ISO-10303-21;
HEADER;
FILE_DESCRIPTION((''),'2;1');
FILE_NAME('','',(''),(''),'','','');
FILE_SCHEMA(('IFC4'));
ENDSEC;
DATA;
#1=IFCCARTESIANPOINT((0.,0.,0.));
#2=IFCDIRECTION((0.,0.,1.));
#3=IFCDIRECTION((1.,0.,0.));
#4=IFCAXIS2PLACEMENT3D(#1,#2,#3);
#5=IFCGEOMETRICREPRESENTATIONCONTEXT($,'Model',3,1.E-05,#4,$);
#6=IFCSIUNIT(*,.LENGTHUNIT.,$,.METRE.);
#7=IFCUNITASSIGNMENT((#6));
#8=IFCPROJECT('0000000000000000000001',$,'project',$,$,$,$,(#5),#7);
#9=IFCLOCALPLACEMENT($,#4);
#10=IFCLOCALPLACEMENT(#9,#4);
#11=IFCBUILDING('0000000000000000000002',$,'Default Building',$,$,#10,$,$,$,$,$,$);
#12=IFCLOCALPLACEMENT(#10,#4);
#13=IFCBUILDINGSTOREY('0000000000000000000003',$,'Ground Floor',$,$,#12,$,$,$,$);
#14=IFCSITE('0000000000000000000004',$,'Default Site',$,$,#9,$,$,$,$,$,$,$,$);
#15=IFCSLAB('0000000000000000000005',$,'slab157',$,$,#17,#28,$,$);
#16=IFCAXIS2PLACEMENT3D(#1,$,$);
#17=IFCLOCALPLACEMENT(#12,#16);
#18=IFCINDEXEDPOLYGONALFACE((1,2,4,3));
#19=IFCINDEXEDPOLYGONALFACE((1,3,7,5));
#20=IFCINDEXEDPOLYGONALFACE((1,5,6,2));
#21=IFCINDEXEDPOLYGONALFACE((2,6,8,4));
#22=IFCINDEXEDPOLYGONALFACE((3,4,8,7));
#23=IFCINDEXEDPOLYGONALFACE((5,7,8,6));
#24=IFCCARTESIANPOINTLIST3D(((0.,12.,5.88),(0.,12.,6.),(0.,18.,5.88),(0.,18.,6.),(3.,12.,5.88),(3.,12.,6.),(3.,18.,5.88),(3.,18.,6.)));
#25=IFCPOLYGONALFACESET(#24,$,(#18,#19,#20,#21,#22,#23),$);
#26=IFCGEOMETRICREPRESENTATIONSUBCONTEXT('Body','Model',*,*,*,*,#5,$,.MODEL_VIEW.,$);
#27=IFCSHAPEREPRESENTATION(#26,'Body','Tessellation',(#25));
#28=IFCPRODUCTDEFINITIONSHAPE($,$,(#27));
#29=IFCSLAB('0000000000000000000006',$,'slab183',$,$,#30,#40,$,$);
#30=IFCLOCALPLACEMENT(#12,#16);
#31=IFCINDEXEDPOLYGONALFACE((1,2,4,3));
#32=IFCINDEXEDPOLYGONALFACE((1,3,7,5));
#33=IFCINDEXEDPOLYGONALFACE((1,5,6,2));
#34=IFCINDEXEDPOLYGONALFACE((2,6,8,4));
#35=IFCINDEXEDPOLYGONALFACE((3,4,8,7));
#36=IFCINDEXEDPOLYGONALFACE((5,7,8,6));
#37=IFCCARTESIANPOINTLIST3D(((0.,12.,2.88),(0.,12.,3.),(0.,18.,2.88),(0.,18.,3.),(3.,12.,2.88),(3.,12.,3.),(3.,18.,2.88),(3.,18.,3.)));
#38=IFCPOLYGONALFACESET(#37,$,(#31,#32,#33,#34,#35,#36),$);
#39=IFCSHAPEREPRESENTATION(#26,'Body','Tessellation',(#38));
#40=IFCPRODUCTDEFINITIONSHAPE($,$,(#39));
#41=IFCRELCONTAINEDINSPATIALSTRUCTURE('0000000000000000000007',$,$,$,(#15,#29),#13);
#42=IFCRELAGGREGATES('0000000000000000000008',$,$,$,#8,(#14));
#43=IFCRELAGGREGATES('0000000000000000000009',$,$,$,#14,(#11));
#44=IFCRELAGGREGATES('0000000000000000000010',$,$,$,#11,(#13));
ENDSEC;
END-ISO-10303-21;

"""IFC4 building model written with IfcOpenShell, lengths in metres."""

from ifc_helpers import new_model, si_unit, frame, origin_with_axes, place, context, subcontext, project, spatial, indexed_curve, outline, extrude, element, save


model = new_model("IFC4")

# Units and contexts
model_context = context("Model", 3, precision=1e-05, world=origin_with_axes())
body_context = subcontext(model_context, "Body", "Model", "MODEL_VIEW")
ifc_project = project(units=[si_unit("LENGTHUNIT", "METRE")], contexts=[model_context])

# Site, building, storey
site_placement = place(None, origin_with_axes())
site = spatial("IfcSite", under=ifc_project, at=site_placement, Name="Default Site")
building_placement = place(site_placement, origin_with_axes())
building = spatial("IfcBuilding", under=site, at=building_placement, Name="Default Building")
storey_placement = place(building_placement, origin_with_axes())
storey = spatial("IfcBuildingStorey", under=building, at=storey_placement, Name="Ground Floor")

# Slabs
for number, where, z_axis, x_axis, name in (
    (1, (0.0, 12.0, 5.88), (0.0, 0.0, 1.0), (1.0, 0.0, 0.0), "slab157"),
    (2, (0.0, 12.0, 2.88), (0.0, 0.0, 1.0), (1.0, 0.0, 0.0), "slab183"),
):
    element("IfcSlab", number, at=place(storey_placement, frame(where, z_axis=z_axis, x_axis=x_axis)), inside=storey, Name=name, context=body_context, shape_type="SweptSolid", body=[
        extrude(outline(indexed_curve([(0.0, 0.0), (0.0, 6.0), (3.0, 6.0), (3.0, 0.0), (0.0, 0.0)], self_intersect=False)), origin_with_axes(), (0.0, 0.0, 1.0), 0.12),
    ])

save(model, "model.ifc")
